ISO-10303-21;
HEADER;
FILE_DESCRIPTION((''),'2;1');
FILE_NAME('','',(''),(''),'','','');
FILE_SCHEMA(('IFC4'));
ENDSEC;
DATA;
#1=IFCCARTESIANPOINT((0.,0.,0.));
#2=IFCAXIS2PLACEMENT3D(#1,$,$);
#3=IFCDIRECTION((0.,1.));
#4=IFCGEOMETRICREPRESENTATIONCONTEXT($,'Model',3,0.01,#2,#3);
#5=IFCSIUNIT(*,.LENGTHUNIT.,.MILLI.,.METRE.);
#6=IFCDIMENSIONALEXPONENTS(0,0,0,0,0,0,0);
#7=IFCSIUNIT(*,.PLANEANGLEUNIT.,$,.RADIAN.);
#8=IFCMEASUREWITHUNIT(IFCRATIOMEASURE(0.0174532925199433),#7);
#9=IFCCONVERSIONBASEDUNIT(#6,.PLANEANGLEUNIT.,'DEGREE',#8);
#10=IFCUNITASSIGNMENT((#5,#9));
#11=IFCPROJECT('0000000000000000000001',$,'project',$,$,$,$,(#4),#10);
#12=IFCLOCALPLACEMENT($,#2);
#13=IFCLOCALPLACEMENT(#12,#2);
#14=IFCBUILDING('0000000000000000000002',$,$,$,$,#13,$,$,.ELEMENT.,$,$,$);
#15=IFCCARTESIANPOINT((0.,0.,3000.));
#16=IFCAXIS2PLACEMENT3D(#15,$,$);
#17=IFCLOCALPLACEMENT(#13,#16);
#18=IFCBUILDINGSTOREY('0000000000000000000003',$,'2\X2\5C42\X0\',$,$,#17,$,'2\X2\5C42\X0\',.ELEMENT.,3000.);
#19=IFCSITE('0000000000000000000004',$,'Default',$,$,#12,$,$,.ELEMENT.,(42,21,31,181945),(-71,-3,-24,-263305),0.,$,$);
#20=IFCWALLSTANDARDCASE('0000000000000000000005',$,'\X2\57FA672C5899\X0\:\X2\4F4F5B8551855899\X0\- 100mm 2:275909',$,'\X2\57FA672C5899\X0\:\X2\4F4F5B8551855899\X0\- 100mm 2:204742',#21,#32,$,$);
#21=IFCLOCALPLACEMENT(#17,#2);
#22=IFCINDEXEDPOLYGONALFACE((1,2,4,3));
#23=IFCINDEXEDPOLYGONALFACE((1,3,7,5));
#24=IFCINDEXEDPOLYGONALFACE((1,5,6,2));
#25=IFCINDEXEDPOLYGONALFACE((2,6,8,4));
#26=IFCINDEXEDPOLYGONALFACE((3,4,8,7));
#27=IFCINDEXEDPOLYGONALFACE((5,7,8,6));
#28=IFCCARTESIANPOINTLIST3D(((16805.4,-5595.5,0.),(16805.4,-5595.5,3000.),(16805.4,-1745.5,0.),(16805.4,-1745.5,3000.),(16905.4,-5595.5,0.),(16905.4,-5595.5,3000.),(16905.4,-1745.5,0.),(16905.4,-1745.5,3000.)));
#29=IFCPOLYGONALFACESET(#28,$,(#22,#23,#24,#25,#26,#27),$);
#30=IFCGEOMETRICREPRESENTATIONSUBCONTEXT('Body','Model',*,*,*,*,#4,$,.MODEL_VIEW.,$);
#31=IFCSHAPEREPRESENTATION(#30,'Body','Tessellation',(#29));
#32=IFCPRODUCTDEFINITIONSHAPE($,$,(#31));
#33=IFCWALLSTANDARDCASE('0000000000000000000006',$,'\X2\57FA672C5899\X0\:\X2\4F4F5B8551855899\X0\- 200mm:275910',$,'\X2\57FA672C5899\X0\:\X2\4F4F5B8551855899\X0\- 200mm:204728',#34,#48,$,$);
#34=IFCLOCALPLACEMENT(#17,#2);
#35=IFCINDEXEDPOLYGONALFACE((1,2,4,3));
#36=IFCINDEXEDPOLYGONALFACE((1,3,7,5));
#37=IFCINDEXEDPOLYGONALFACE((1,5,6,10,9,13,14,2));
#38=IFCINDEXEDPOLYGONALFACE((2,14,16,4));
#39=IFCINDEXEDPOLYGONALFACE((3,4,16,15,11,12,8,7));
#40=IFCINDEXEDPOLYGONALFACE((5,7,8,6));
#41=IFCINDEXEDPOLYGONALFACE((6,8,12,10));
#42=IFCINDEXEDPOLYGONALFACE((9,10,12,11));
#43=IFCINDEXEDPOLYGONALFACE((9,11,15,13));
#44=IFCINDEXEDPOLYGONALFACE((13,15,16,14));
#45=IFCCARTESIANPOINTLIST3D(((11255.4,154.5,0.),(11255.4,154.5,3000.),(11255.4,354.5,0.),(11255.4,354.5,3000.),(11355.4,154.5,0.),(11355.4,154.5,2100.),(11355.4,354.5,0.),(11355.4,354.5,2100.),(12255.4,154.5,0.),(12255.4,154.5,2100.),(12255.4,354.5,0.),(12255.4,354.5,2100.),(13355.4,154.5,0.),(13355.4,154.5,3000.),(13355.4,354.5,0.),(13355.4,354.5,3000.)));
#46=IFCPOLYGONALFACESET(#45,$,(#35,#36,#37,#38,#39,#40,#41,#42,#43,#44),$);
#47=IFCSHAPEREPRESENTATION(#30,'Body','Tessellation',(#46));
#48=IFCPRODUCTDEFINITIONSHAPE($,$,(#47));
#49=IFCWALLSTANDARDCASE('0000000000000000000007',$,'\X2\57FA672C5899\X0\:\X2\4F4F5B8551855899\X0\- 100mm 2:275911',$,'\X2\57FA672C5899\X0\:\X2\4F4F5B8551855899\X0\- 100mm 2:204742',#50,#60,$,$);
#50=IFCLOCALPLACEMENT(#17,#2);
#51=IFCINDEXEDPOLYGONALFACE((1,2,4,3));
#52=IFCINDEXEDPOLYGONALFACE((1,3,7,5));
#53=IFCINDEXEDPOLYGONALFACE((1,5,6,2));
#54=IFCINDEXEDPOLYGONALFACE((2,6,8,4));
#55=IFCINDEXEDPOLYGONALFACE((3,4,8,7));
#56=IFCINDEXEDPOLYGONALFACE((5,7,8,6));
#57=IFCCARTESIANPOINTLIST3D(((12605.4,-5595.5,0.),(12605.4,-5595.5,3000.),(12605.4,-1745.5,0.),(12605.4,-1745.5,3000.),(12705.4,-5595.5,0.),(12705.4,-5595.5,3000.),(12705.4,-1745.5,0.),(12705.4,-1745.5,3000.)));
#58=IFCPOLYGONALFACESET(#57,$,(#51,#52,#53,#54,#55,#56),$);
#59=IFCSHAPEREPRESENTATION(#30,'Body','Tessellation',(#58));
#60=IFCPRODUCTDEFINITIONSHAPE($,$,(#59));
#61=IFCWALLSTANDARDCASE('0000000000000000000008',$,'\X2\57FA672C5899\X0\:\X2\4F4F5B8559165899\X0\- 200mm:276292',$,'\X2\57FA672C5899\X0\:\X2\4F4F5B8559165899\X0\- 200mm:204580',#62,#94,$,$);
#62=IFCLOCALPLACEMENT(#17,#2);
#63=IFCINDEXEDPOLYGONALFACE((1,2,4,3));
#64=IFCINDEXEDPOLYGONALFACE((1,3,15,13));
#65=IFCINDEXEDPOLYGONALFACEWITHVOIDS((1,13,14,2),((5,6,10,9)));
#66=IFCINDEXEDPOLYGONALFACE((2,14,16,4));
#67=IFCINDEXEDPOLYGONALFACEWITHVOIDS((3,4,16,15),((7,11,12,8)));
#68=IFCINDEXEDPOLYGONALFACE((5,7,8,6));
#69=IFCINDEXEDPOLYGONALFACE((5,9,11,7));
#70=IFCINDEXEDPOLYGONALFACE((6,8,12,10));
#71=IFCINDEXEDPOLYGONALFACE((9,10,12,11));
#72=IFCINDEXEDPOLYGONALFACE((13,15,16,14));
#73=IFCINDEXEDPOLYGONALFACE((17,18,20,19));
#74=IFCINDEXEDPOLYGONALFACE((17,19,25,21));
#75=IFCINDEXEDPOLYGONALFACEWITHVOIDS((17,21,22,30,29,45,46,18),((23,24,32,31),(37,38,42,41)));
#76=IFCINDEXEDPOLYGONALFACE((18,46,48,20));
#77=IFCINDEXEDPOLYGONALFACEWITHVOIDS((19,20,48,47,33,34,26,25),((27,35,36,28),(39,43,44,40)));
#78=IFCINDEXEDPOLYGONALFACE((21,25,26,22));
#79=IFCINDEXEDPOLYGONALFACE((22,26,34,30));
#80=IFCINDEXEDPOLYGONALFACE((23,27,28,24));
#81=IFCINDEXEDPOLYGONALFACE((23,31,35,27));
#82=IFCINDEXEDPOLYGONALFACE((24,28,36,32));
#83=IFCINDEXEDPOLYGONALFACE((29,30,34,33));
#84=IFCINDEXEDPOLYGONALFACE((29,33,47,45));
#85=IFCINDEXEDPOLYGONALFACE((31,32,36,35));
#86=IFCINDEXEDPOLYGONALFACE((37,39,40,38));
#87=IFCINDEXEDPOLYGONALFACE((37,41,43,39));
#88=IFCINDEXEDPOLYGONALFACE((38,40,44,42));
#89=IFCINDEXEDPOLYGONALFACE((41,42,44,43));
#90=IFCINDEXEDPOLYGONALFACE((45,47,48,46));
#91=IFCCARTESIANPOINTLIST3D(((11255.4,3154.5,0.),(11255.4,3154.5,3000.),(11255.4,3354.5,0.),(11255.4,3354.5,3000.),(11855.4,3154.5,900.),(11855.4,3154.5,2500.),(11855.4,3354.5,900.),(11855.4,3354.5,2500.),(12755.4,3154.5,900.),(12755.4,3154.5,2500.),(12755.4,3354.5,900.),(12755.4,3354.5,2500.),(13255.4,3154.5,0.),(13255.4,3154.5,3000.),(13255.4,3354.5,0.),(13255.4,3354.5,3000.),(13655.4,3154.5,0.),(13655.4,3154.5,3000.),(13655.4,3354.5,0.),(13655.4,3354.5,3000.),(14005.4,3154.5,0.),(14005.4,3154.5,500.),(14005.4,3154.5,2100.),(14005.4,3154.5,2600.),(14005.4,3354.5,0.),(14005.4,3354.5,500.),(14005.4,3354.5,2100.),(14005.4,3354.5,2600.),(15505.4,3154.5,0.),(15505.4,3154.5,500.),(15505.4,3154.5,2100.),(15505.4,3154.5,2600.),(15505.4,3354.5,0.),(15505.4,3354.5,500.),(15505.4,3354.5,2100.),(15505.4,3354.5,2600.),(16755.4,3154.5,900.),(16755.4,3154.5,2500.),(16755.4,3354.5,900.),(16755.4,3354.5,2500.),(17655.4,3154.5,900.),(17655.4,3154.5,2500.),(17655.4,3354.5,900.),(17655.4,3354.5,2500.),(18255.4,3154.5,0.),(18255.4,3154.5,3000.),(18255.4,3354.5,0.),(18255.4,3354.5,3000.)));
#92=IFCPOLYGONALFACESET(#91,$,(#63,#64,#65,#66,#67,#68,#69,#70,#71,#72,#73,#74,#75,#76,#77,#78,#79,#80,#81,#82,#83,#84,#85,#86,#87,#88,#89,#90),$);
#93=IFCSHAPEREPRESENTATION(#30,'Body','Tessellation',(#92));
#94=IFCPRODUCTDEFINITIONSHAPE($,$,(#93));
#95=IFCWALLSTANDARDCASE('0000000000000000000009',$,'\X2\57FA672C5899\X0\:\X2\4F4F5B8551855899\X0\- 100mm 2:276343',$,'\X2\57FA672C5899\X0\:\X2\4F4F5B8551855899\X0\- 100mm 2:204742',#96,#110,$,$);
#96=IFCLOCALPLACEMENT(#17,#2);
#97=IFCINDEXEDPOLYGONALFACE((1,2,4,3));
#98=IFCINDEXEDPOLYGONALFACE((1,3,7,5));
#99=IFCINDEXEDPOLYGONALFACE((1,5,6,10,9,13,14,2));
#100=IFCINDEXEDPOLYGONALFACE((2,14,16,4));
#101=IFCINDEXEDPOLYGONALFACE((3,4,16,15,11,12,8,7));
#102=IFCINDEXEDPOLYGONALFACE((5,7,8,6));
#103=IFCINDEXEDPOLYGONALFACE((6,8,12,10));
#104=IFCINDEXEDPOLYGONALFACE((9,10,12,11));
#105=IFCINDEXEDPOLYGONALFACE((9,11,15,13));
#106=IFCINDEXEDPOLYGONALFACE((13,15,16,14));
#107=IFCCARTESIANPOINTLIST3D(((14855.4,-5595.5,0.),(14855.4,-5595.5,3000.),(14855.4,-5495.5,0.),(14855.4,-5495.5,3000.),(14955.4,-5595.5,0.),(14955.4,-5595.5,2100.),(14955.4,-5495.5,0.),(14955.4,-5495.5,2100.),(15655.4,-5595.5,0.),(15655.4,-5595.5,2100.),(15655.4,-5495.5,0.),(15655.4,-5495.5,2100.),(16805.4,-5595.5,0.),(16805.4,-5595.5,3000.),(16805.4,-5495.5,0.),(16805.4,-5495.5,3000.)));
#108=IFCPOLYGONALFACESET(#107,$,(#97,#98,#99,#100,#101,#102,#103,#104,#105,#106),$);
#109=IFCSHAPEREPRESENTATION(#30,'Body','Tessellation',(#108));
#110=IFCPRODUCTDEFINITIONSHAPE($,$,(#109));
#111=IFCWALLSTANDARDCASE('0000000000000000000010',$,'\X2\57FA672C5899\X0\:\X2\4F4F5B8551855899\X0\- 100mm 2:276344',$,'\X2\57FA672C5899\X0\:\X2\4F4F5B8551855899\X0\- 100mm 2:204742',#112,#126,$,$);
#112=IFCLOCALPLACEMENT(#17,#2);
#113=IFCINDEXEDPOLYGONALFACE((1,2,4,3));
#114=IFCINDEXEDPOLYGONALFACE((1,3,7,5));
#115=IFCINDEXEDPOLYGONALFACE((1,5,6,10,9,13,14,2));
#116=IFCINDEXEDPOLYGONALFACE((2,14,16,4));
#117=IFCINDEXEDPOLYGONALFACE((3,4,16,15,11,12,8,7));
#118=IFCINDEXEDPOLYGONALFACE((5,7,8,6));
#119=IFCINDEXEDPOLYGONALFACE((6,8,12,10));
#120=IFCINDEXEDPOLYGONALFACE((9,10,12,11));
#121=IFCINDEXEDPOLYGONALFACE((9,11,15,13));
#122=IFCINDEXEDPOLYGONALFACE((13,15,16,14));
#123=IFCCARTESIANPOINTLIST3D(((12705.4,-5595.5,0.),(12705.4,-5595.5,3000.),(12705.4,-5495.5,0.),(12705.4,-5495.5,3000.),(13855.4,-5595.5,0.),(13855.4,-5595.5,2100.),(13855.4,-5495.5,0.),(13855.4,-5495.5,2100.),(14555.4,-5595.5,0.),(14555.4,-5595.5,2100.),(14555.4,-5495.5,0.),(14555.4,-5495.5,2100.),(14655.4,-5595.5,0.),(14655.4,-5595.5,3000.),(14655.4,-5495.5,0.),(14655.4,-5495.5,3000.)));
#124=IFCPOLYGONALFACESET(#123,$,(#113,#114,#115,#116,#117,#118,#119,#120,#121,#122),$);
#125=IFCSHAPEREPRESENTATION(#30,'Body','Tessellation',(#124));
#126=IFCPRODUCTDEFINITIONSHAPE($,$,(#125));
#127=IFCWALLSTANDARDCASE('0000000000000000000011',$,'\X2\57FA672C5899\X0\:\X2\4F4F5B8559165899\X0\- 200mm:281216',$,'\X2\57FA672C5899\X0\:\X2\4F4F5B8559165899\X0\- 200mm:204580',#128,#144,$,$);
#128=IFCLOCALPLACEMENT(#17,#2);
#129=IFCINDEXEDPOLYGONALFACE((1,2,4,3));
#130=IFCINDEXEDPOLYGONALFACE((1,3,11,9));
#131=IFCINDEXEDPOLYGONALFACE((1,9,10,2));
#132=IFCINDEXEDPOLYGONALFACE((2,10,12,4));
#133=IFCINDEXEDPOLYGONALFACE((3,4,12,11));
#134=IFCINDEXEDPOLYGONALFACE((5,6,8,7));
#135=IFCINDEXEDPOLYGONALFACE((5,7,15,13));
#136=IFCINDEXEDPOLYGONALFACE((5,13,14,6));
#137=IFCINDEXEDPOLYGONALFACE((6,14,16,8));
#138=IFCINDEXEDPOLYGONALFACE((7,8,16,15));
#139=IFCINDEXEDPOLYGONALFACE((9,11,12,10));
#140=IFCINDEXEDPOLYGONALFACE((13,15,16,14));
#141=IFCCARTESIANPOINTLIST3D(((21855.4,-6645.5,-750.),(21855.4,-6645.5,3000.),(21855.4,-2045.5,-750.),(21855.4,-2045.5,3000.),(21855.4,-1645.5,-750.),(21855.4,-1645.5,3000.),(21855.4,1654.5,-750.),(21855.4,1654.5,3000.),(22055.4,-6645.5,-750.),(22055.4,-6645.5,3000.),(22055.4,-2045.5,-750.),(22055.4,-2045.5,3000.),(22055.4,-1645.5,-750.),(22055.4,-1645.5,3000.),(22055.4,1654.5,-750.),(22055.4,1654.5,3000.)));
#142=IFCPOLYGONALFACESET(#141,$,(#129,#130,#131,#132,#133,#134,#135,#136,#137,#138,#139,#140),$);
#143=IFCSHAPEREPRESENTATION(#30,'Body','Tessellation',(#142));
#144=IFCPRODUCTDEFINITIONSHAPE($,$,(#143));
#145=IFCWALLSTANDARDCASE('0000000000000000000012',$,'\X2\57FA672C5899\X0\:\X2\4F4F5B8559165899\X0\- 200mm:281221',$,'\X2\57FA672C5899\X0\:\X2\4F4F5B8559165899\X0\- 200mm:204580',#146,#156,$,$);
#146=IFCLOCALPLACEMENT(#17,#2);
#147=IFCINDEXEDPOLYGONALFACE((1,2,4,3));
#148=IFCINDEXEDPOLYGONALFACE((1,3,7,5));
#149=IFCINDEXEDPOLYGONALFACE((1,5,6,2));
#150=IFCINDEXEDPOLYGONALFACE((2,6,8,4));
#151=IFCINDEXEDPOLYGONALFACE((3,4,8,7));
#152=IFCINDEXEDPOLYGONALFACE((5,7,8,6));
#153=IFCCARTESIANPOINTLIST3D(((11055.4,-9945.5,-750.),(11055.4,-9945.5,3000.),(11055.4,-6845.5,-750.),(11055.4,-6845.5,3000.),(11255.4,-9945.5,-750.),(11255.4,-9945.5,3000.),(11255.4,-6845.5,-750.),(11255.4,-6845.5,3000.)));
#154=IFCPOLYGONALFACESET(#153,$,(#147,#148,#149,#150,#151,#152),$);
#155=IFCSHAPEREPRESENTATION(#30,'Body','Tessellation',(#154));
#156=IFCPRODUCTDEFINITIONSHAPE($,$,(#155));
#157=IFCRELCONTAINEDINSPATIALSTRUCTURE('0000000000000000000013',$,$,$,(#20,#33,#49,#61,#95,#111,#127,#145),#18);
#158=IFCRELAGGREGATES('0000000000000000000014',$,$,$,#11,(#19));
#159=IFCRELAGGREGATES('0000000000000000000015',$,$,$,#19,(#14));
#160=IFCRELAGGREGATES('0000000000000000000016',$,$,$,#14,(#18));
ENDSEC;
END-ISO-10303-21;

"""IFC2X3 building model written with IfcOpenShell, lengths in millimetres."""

from ifc_helpers import new_model, entity, si_unit, converted_unit, direction, frame, frame_2d, origin, origin_2d_with_axis, place, context, subcontext, project, spatial, polyline, rectangle, extrude, clip, bounded_halfspace, element, save


model = new_model("IFC2X3")

# Units and contexts
model_context = context("Model", 3, precision=0.01, world=origin(), true_north=direction((0.0, 1.0)))
body_context = subcontext(model_context, "Body", "Model", "MODEL_VIEW")
ifc_project = project(units=[si_unit("LENGTHUNIT", "METRE", prefix="MILLI"), converted_unit("PLANEANGLEUNIT", "DEGREE", entity("IfcRatioMeasure", 0.0174532925199433), si_unit("PLANEANGLEUNIT", "RADIAN"), dimensions=[0, 0, 0, 0, 0, 0, 0])], contexts=[model_context])

# Site, building, storey
site_placement = place(None, origin())
site = spatial("IfcSite", under=ifc_project, at=site_placement, Name="Default", CompositionType="ELEMENT", RefLatitude=(42, 21, 31, 181945), RefLongitude=(-71, -3, -24, -263305), RefElevation=0.0)
building_placement = place(site_placement, origin())
building = spatial("IfcBuilding", under=site, at=building_placement, CompositionType="ELEMENT")
storey_placement = place(building_placement, frame((0.0, 0.0, 3000.0)))
storey = spatial("IfcBuildingStorey", under=building, at=storey_placement, Name="2层", LongName="2层", CompositionType="ELEMENT", Elevation=3000.0)

# Wall
wall_1_placement = place(storey_placement, frame((16855.4, -1745.5, 0.0), z_axis=(0.0, 0.0, 1.0), x_axis=(0.0, -1.0, 0.0)))
element("IfcWallStandardCase", 1, at=wall_1_placement, inside=storey, Name="基本墙:住宅内墙- 100mm 2:275909", ObjectType="基本墙:住宅内墙- 100mm 2:204742", context=body_context, shape_type="SweptSolid", body=[
    extrude(rectangle(XDim=3850.0, YDim=100.0, at=frame_2d((1925.0, 0.0), x_axis=(-1.0, 0.0))), origin(), (0.0, 0.0, 1.0), 3000.0),
])

# Wall, opening
wall_2_placement = place(storey_placement, frame((11255.4, 254.5, 0.0)))
wall_2 = element("IfcWallStandardCase", 2, at=wall_2_placement, inside=storey, Name="基本墙:住宅内墙- 200mm:275910", ObjectType="基本墙:住宅内墙- 200mm:204728", context=body_context, shape_type="SweptSolid", body=[
    extrude(rectangle(XDim=2100.0, YDim=200.0, at=frame_2d((1050.0, 0.0), x_axis=(-1.0, 0.0))), origin(), (0.0, 0.0, 1.0), 3000.0),
])
opening_1_placement = place(wall_2_placement, frame((100.0, -100.0, 0.0)))
element("IfcOpeningElement", 3, at=opening_1_placement, cuts=wall_2, ObjectType="Opening", context=body_context, shape_type="SweptSolid", body=[
    extrude(rectangle(XDim=2100.0, YDim=900.0, at=frame_2d((1050.0, 450.0), x_axis=(1.0, 0.0))), frame((0.0, 0.0, 0.0), z_axis=(0.0, 1.0, 0.0), x_axis=(0.0, 0.0, 1.0)), (0.0, 0.0, 1.0), 200.0),
])

# Wall
wall_3_placement = place(storey_placement, frame((12655.4, -1745.5, 0.0), z_axis=(0.0, 0.0, 1.0), x_axis=(0.0, -1.0, 0.0)))
element("IfcWallStandardCase", 4, at=wall_3_placement, inside=storey, Name="基本墙:住宅内墙- 100mm 2:275911", ObjectType="基本墙:住宅内墙- 100mm 2:204742", context=body_context, shape_type="SweptSolid", body=[
    extrude(rectangle(XDim=3850.0, YDim=100.0, at=frame_2d((1925.0, 0.0), x_axis=(-1.0, 0.0))), origin(), (0.0, 0.0, 1.0), 3000.0),
])

# Wall, openings
wall_4_placement = place(storey_placement, frame((18255.4, 3254.5, 0.0), z_axis=(0.0, 0.0, 1.0), x_axis=(-1.0, 0.0, 0.0)))
wall_4 = element("IfcWallStandardCase", 5, at=wall_4_placement, inside=storey, Name="基本墙:住宅外墙- 200mm:276292", ObjectType="基本墙:住宅外墙- 200mm:204580", context=body_context, shape_type="SweptSolid", body=[
    extrude(rectangle(XDim=7000.0, YDim=200.0, at=frame_2d((3500.0, 0.0), x_axis=(-1.0, 0.0))), origin(), (0.0, 0.0, 1.0), 3000.0),
])
opening_2_placement = place(wall_4_placement, frame((4250.0, 100.0, 2100.0)))
element("IfcOpeningElement", 6, at=opening_2_placement, cuts=wall_4, ObjectType="Opening", context=body_context, shape_type="SweptSolid", body=[
    extrude(rectangle(XDim=500.0, YDim=1500.0, at=frame_2d((250.0, 750.0), x_axis=(1.0, 0.0))), frame((0.0, 0.0, 0.0), z_axis=(0.0, -1.0, 0.0), x_axis=(0.0, 0.0, 1.0)), (0.0, 0.0, 1.0), 200.0),
])
opening_3_placement = place(wall_4_placement, frame((5500.0, -100.0, 900.0)))
element("IfcOpeningElement", 7, at=opening_3_placement, cuts=wall_4, ObjectType="Opening", context=body_context, shape_type="SweptSolid", body=[
    extrude(rectangle(XDim=1600.0, YDim=900.0, at=frame_2d((800.0, 450.0), x_axis=(1.0, 0.0))), frame((0.0, 0.0, 0.0), z_axis=(0.0, 1.0, 0.0), x_axis=(0.0, 0.0, 1.0)), (0.0, 0.0, 1.0), 200.0),
])
opening_4_placement = place(wall_4_placement, frame((600.0, -100.0, 900.0)))
element("IfcOpeningElement", 8, at=opening_4_placement, cuts=wall_4, ObjectType="Opening", context=body_context, shape_type="SweptSolid", body=[
    extrude(rectangle(XDim=1600.0, YDim=900.0, at=frame_2d((800.0, 450.0), x_axis=(1.0, 0.0))), frame((0.0, 0.0, 0.0), z_axis=(0.0, 1.0, 0.0), x_axis=(0.0, 0.0, 1.0)), (0.0, 0.0, 1.0), 200.0),
])
opening_5_placement = place(wall_4_placement, origin())
element("IfcOpeningElement", 9, at=opening_5_placement, cuts=wall_4, ObjectType="Opening", context=body_context, shape_type="SweptSolid", body=[
    extrude(rectangle(XDim=500.0, YDim=1500.0, at=frame_2d((0.0, 0.0), x_axis=(0.0, 1.0))), frame((3500.0, -1424.0, 3250.0), z_axis=(0.0, 1.0, 0.0), x_axis=(-1.0, 0.0, 0.0)), (0.0, 0.0, 1.0), 3048.0),
])
opening_6_placement = place(wall_4_placement, origin())
element("IfcOpeningElement", 10, at=opening_6_placement, cuts=wall_4, ObjectType="Opening", context=body_context, shape_type="SweptSolid", body=[
    extrude(rectangle(XDim=500.0, YDim=1500.0, at=frame_2d((0.0, 0.0), x_axis=(0.0, 1.0))), frame((3500.0, -1424.0, 250.0), z_axis=(0.0, 1.0, 0.0), x_axis=(-1.0, 0.0, 0.0)), (0.0, 0.0, 1.0), 3048.0),
])
opening_7_placement = place(storey_placement, frame((18255.4, 3254.5, 0.0), z_axis=(0.0, 0.0, 1.0), x_axis=(-1.0, 0.0, 0.0)))
element("IfcOpeningElement", 11, at=opening_7_placement, cuts=wall_4, ObjectType="Opening", context=body_context, shape_type="SweptSolid", body=[
    extrude(rectangle(XDim=3000.0, YDim=200.0, at=frame_2d((0.0, 0.0), x_axis=(1.0, 0.0))), frame((5000.0, 0.0, 1500.0), z_axis=(-1.0, 0.0, 0.0), x_axis=(0.0, 0.0, 1.0)), (0.0, 0.0, 1.0), 400.0),
])

# Walls, openings
wall_5_placement = place(storey_placement, frame((16805.4, -5545.5, 0.0), z_axis=(0.0, 0.0, 1.0), x_axis=(-1.0, 0.0, 0.0)))
wall_5 = element("IfcWallStandardCase", 12, at=wall_5_placement, inside=storey, Name="基本墙:住宅内墙- 100mm 2:276343", ObjectType="基本墙:住宅内墙- 100mm 2:204742", context=body_context, shape_type="SweptSolid", body=[
    extrude(rectangle(XDim=1950.0, YDim=100.0, at=frame_2d((975.0, 0.0), x_axis=(-1.0, 0.0))), origin(), (0.0, 0.0, 1.0), 3000.0),
])
opening_8_placement = place(wall_5_placement, frame((1850.0, 50.0, 0.0)))
element("IfcOpeningElement", 13, at=opening_8_placement, cuts=wall_5, ObjectType="Opening", context=body_context, shape_type="SweptSolid", body=[
    extrude(rectangle(XDim=2100.0, YDim=700.0, at=frame_2d((1050.0, 350.0), x_axis=(1.0, 0.0))), frame((0.0, 0.0, 0.0), z_axis=(0.0, -1.0, 0.0), x_axis=(0.0, 0.0, 1.0)), (0.0, 0.0, 1.0), 100.0),
])
wall_6_placement = place(storey_placement, frame((12705.4, -5545.5, 0.0)))
wall_6 = element("IfcWallStandardCase", 14, at=wall_6_placement, inside=storey, Name="基本墙:住宅内墙- 100mm 2:276344", ObjectType="基本墙:住宅内墙- 100mm 2:204742", context=body_context, shape_type="SweptSolid", body=[
    extrude(rectangle(XDim=1950.0, YDim=100.0, at=frame_2d((975.0, 0.0), x_axis=(-1.0, 0.0))), origin(), (0.0, 0.0, 1.0), 3000.0),
])
opening_9_placement = place(wall_6_placement, frame((1150.0, -50.0, 0.0)))
element("IfcOpeningElement", 15, at=opening_9_placement, cuts=wall_6, ObjectType="Opening", context=body_context, shape_type="SweptSolid", body=[
    extrude(rectangle(XDim=2100.0, YDim=700.0, at=frame_2d((1050.0, 350.0), x_axis=(1.0, 0.0))), frame((0.0, 0.0, 0.0), z_axis=(0.0, 1.0, 0.0), x_axis=(0.0, 0.0, 1.0)), (0.0, 0.0, 1.0), 100.0),
])
wall_7_placement = place(storey_placement, frame((21955.4, -6645.5, -750.0), z_axis=(0.0, 0.0, 1.0), x_axis=(0.0, 1.0, 0.0)))
wall_7 = element("IfcWallStandardCase", 16, at=wall_7_placement, inside=storey, Name="基本墙:住宅外墙- 200mm:281216", ObjectType="基本墙:住宅外墙- 200mm:204580", context=body_context, shape_type="SweptSolid", body=[
    extrude(rectangle(XDim=8300.0, YDim=200.0, at=frame_2d((4150.0, 0.0), x_axis=(-1.0, 0.0))), origin(), (0.0, 0.0, 1.0), 3750.0),
])
opening_10_placement = place(storey_placement, frame((21955.4, -6645.5, -750.0), z_axis=(0.0, 0.0, 1.0), x_axis=(0.0, 1.0, 0.0)))
element("IfcOpeningElement", 17, at=opening_10_placement, cuts=wall_7, ObjectType="Opening", context=body_context, shape_type="SweptSolid", body=[
    extrude(rectangle(XDim=3750.0, YDim=200.0, at=origin_2d_with_axis()), frame((4600.0, 0.0, 1875.0), z_axis=(1.0, 0.0, 0.0), x_axis=(0.0, 0.0, -1.0)), (0.0, 0.0, 1.0), 400.0),
])

# Wall
wall_8_placement = place(storey_placement, frame((11155.4, -6845.5, -750.0), z_axis=(0.0, 0.0, 1.0), x_axis=(0.0, -1.0, 0.0)))
element("IfcWallStandardCase", 18, at=wall_8_placement, inside=storey, Name="基本墙:住宅外墙- 200mm:281221", ObjectType="基本墙:住宅外墙- 200mm:204580", context=body_context, shape_type="Clipping", body=[
    clip(extrude(rectangle(XDim=3100.0, YDim=200.0, at=frame_2d((1550.0, 0.0), x_axis=(-1.0, 0.0))), origin(), (0.0, 0.0, 1.0), 3750.0), bounded_halfspace(frame((3100.0, -100.0, 3750.0), z_axis=(-1.0, 0.0, 0.0), x_axis=(0.0, 0.0, -1.0)), True, frame((3100.0, -100.0, 3750.0), z_axis=(-1.0, 0.0, 0.0), x_axis=(0.0, 0.0, -1.0)), polyline([(0.0, 0.0), (0.0, -200.0), (3750.0, -200.0), (3750.0, 0.0), (0.0, 0.0)]))),
])

save(model, "model.ifc")
